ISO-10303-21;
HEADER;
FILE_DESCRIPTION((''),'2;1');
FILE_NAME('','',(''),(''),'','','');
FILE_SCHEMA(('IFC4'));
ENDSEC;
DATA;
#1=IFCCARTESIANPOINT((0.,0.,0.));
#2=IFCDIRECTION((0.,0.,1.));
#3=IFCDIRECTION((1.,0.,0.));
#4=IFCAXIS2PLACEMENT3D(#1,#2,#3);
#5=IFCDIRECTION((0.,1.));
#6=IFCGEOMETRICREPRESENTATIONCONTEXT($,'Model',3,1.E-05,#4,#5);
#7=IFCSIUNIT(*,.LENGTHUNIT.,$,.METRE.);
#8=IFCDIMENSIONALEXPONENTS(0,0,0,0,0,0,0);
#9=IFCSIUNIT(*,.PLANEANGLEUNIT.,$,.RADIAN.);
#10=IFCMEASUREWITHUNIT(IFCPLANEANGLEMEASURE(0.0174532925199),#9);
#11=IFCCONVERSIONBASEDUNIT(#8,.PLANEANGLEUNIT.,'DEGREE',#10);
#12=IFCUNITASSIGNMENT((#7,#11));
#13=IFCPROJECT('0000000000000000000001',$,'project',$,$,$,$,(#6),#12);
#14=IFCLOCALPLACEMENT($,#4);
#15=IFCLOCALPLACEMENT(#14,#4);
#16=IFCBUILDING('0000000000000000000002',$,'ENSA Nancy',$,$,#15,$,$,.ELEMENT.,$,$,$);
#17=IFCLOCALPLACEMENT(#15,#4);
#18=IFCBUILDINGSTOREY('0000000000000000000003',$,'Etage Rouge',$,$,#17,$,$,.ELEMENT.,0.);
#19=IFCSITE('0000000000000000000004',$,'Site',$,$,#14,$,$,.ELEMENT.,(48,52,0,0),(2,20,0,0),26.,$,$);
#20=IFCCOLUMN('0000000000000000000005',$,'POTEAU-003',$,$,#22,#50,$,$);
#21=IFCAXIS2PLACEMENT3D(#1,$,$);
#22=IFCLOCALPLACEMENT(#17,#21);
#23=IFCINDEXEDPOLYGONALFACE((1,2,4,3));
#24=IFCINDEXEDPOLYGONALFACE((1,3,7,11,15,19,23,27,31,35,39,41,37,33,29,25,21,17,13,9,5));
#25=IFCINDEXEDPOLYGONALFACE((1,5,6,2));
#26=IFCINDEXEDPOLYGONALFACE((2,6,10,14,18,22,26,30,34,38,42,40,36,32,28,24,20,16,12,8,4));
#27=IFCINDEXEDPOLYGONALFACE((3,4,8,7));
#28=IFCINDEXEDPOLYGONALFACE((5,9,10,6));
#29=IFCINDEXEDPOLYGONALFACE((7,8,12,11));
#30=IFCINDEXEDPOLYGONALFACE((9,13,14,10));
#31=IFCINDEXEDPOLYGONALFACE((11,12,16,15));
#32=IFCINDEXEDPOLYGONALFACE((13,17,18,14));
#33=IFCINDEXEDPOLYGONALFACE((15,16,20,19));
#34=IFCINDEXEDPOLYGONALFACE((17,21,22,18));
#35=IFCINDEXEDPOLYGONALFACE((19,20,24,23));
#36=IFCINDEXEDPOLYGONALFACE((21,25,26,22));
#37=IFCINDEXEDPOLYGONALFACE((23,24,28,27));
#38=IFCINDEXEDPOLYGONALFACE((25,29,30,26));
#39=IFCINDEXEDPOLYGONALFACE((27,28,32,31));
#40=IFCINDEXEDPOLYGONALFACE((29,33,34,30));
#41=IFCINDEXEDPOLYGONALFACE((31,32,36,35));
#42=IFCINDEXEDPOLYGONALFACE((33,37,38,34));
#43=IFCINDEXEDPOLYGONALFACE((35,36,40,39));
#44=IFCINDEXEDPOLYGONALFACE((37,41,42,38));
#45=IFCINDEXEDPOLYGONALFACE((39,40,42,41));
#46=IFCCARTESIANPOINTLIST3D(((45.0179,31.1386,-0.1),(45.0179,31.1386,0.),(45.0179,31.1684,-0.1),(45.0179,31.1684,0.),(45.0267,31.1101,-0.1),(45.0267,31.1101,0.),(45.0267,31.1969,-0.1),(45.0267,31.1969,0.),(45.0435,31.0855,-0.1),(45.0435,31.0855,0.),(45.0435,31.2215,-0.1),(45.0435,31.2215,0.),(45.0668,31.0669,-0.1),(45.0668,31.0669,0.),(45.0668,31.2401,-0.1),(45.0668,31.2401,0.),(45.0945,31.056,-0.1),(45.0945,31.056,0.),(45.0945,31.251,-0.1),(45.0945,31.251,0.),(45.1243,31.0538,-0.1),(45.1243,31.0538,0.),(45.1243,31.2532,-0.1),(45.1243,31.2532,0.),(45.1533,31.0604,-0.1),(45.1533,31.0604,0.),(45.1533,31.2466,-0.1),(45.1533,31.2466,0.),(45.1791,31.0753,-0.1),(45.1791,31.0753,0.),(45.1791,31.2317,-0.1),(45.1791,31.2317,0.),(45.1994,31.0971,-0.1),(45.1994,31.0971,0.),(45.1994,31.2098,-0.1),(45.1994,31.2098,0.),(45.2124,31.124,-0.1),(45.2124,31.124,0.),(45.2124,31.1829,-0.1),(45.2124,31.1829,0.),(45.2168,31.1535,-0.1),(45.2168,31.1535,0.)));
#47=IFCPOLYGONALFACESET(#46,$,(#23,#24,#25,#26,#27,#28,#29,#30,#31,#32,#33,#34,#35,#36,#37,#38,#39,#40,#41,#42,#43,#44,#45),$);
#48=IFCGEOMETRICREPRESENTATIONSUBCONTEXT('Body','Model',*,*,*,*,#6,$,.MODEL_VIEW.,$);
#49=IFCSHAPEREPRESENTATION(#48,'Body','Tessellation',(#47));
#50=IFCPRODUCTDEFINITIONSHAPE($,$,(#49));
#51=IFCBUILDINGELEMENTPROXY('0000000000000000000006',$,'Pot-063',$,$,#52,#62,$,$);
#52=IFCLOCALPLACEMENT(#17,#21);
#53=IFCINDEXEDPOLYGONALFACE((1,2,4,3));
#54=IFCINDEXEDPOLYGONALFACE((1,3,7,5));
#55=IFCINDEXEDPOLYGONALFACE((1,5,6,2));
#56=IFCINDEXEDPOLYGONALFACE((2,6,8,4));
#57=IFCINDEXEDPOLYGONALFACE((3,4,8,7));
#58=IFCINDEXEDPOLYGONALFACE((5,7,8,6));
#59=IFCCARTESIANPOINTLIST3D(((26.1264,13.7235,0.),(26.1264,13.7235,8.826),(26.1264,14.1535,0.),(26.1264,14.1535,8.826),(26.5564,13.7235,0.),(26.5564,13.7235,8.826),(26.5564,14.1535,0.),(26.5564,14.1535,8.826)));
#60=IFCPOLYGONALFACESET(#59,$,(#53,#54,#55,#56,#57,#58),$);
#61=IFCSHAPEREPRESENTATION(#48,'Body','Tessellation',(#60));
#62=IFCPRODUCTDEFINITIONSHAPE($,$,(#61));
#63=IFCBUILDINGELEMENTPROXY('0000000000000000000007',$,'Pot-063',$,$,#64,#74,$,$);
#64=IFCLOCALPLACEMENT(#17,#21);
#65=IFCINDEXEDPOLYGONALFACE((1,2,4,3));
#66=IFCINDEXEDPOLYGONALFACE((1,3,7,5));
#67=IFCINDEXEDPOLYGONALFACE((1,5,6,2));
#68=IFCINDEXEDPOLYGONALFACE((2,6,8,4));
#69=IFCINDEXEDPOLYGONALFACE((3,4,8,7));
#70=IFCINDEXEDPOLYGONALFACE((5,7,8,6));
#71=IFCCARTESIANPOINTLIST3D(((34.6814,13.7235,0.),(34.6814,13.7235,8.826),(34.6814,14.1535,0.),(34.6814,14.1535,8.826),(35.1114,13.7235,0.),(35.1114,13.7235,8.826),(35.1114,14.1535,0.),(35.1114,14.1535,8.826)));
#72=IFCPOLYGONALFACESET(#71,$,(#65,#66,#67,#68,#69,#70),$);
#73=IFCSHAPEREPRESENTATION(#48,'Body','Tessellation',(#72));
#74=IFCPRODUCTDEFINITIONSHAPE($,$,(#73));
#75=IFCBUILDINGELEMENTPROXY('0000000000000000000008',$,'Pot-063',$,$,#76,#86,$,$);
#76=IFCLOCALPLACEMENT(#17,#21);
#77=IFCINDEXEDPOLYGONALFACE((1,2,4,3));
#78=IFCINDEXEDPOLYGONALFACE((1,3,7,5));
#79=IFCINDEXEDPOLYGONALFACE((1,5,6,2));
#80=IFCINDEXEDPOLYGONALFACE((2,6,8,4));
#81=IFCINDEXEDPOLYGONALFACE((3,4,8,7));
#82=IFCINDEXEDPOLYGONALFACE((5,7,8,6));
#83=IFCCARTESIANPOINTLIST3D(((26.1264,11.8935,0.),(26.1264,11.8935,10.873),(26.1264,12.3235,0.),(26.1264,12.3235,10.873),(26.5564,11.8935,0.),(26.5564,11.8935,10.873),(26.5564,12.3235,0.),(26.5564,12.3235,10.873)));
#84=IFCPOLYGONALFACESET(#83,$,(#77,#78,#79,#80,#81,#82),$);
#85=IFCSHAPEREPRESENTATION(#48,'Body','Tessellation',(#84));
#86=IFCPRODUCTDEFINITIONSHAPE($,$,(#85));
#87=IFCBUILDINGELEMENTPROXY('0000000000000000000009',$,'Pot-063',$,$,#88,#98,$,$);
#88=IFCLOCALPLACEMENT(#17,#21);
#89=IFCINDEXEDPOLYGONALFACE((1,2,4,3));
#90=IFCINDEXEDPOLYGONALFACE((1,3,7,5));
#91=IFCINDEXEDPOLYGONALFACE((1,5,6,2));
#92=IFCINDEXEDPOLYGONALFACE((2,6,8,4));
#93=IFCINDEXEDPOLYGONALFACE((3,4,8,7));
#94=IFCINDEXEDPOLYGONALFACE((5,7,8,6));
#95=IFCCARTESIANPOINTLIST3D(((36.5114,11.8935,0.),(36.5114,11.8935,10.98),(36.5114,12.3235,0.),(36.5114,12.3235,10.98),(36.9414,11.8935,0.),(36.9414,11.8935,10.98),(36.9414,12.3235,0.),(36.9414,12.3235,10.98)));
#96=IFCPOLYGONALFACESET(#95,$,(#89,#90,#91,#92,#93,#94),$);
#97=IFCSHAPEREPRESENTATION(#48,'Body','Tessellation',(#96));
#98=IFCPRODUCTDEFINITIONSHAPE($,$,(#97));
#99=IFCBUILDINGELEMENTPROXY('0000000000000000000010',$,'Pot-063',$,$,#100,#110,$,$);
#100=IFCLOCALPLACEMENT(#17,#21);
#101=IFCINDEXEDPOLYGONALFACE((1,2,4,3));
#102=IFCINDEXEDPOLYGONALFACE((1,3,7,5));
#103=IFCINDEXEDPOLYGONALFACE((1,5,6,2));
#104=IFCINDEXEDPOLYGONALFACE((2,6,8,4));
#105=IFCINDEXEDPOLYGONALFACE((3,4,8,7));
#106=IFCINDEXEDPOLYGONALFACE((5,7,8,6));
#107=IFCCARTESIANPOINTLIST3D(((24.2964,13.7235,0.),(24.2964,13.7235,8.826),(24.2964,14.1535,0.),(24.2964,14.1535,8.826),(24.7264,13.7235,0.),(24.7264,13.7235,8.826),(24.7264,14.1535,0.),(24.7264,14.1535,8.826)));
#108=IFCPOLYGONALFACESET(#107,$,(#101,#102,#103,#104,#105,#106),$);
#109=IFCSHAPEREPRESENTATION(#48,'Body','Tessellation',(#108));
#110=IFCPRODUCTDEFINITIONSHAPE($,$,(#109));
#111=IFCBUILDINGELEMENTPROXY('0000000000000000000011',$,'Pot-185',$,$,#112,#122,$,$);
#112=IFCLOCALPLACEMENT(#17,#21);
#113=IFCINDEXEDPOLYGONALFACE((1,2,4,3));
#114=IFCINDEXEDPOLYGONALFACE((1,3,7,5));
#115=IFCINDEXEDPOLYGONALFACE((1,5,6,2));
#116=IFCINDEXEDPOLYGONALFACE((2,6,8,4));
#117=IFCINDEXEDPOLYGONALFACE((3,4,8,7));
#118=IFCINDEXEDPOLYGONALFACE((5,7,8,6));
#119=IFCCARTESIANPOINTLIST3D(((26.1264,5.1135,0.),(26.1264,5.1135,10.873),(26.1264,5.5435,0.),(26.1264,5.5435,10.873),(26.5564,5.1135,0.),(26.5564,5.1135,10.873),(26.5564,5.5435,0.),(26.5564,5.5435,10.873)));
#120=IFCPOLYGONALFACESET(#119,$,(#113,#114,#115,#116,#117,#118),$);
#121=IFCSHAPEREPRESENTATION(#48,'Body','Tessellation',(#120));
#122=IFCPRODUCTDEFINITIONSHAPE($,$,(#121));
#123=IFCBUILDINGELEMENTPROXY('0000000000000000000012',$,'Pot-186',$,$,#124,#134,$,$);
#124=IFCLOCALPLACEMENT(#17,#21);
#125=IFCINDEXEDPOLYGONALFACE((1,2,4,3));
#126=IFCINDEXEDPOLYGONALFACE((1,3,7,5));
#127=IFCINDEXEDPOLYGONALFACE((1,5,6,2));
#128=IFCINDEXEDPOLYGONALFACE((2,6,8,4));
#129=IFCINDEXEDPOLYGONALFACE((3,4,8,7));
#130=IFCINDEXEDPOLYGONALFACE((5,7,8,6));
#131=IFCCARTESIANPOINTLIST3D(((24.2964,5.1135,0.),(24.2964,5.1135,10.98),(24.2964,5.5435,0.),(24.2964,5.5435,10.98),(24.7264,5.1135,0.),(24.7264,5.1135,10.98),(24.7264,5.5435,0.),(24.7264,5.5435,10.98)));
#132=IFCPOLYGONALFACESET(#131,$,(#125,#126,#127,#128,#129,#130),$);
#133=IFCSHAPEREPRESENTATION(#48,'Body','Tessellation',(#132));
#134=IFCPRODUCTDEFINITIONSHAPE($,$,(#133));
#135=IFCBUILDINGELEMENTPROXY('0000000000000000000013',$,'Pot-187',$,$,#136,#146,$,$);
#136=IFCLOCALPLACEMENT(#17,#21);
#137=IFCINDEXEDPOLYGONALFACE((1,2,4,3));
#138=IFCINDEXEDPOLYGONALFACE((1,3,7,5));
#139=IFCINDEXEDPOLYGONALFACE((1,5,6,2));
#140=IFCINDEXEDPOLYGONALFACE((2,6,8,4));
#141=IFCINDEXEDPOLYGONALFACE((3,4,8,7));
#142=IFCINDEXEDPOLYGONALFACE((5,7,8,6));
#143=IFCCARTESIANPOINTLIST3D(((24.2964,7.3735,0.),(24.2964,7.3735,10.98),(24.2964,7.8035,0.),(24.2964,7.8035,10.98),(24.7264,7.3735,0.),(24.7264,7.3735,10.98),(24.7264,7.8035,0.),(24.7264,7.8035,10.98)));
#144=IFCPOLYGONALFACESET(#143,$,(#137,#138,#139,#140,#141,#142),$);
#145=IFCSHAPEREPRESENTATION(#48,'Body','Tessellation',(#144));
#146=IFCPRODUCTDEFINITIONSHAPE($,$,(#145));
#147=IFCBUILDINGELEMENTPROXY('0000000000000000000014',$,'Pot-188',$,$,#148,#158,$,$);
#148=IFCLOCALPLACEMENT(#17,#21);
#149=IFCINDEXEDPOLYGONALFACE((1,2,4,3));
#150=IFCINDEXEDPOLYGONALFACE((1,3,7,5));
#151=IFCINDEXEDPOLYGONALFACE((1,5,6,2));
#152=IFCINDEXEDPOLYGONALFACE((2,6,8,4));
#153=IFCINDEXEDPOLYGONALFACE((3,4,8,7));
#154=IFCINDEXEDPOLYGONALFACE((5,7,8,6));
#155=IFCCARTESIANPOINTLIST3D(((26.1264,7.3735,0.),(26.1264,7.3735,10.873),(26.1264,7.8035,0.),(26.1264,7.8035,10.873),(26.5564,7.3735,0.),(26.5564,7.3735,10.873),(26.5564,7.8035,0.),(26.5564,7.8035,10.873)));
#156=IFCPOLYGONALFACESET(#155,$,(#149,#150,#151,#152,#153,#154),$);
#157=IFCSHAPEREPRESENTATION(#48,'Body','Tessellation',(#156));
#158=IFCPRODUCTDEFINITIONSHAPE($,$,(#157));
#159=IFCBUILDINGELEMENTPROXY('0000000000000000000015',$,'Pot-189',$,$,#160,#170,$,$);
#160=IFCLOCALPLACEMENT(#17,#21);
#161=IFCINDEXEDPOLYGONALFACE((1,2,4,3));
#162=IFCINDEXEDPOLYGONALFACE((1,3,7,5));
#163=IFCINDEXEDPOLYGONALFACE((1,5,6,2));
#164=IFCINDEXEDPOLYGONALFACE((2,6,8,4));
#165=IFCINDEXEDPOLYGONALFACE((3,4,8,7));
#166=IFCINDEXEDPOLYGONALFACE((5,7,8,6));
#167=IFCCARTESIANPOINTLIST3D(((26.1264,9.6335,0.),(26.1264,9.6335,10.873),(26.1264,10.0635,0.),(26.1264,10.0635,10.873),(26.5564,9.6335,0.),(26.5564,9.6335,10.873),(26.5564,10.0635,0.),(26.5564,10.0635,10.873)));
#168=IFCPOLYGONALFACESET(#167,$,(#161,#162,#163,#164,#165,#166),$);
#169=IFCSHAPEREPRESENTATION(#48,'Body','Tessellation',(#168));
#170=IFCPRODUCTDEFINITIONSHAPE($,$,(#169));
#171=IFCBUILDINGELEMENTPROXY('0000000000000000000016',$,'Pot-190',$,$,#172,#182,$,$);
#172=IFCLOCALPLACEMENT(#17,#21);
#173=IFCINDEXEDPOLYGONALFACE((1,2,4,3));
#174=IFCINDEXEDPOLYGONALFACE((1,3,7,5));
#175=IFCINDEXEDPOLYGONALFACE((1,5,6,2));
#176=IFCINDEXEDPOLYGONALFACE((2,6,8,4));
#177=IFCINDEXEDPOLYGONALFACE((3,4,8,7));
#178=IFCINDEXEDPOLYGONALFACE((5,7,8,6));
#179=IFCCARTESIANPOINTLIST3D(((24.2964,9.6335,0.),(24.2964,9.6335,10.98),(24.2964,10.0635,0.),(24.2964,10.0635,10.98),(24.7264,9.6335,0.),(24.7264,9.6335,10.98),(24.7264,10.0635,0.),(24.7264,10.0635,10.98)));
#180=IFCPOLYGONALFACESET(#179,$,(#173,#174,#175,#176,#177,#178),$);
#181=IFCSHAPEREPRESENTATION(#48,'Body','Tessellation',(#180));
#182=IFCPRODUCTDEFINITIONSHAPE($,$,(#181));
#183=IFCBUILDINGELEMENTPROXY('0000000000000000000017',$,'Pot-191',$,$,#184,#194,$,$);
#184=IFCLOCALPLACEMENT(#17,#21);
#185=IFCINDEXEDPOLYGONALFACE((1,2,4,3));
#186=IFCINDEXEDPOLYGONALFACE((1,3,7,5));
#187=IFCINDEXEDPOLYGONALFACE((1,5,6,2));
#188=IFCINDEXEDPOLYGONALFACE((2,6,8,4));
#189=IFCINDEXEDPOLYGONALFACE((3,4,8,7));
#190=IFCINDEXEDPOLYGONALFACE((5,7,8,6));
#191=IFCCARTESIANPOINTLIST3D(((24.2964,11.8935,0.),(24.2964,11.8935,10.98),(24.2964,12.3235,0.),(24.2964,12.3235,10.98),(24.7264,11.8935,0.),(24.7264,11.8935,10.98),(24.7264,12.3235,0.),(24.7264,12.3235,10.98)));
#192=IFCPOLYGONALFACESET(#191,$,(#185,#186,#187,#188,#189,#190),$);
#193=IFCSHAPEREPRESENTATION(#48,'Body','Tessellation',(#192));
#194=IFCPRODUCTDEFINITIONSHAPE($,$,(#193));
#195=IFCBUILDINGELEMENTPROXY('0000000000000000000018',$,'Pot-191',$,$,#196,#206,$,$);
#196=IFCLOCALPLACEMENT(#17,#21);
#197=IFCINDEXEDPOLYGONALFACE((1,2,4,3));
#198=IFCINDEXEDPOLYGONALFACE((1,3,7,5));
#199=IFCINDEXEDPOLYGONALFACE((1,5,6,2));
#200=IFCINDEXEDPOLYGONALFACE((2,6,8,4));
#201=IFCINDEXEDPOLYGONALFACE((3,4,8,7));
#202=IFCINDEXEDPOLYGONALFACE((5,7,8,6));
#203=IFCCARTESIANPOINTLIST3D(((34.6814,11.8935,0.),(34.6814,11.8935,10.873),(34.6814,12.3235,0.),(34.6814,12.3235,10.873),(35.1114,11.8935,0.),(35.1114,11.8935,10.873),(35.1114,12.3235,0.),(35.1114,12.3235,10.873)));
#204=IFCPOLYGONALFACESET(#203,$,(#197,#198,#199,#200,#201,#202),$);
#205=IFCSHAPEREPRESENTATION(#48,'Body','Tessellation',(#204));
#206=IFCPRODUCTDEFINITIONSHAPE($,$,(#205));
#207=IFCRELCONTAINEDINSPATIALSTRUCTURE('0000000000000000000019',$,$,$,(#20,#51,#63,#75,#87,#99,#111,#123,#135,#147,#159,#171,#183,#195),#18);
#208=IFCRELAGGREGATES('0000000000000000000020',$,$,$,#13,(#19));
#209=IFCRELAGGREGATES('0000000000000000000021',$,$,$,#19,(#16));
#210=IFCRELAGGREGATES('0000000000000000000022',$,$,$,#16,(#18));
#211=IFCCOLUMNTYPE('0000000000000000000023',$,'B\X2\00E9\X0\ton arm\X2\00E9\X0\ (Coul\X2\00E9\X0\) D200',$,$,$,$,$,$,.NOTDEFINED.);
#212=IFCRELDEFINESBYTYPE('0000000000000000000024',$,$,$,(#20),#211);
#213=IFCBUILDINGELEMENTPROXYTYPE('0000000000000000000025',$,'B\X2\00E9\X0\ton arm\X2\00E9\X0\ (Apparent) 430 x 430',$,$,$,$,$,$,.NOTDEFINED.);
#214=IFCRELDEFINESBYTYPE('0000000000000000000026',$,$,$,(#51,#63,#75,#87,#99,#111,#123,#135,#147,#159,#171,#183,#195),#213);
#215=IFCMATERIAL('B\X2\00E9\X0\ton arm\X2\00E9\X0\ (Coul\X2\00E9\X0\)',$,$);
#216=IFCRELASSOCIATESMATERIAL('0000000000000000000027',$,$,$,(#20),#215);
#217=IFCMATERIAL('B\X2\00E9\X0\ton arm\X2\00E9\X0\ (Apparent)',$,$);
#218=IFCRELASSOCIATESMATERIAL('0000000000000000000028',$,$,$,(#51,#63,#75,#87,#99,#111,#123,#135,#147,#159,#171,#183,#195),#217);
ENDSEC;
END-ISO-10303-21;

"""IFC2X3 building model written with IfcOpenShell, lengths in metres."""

from ifc_helpers import new_model, entity, si_unit, converted_unit, direction, frame, origin_with_axes, origin_2d_with_axis, place, context, subcontext, project, spatial, rectangle, circle, extrude, material, type_object, element, save


model = new_model("IFC2X3")

# Units and contexts
model_context = context("Model", 3, precision=1e-05, world=origin_with_axes(), true_north=direction((0.0, 1.0)))
body_context = subcontext(model_context, "Body", "Model", "MODEL_VIEW")
ifc_project = project(units=[si_unit("LENGTHUNIT", "METRE"), converted_unit("PLANEANGLEUNIT", "DEGREE", entity("IfcPlaneAngleMeasure", 0.0174532925199), si_unit("PLANEANGLEUNIT", "RADIAN"), dimensions=[0, 0, 0, 0, 0, 0, 0])], contexts=[model_context])

# Site, building, storey
site_placement = place(None, origin_with_axes())
site = spatial("IfcSite", under=ifc_project, at=site_placement, Name="Site", CompositionType="ELEMENT", RefLatitude=(48, 52, 0, 0), RefLongitude=(2, 20, 0, 0), RefElevation=26.0)
building_placement = place(site_placement, origin_with_axes())
building = spatial("IfcBuilding", under=site, at=building_placement, Name="ENSA Nancy", CompositionType="ELEMENT")
storey_placement = place(building_placement, origin_with_axes())
storey = spatial("IfcBuildingStorey", under=building, at=storey_placement, Name="Etage Rouge", CompositionType="ELEMENT", Elevation=0.0)

# Column
ifc_material_1 = material(Name="Béton armé (Coulé)")
column_type = type_object("IfcColumnType", Name="Béton armé (Coulé) D200", PredefinedType="NOTDEFINED")
column_placement = place(storey_placement, frame((45.1168, 31.1535, -0.1), z_axis=(0.0, 0.0, 1.0), x_axis=(1.0, 0.0, 0.0)))
element("IfcColumn", 1, at=column_placement, inside=storey, type_object=column_type, material=ifc_material_1, Name="POTEAU-003", context=body_context, shape_type="SweptSolid", body=[
    extrude(circle(Radius=0.1, at=origin_2d_with_axis()), origin_with_axes(), (0.0, 0.0, 1.0), 0.1),
])

# Building element proxies
ifc_material_2 = material(Name="Béton armé (Apparent)")
building_element_proxy_type_1 = type_object("IfcBuildingElementProxyType", Name="Béton armé (Apparent) 430 x 430", PredefinedType="NOTDEFINED")
for number, where, z_axis, x_axis, name in (
    (2, (26.3414, 13.9385, 0.0), (0.0, 0.0, 1.0), (1.0, 0.0, 0.0), "Pot-063"),
    (3, (34.8964, 13.9385, 0.0), (0.0, 0.0, 1.0), (1.0, 0.0, 0.0), "Pot-063"),
):
    element("IfcBuildingElementProxy", number, at=place(storey_placement, frame(where, z_axis=z_axis, x_axis=x_axis)), inside=storey, type_object=building_element_proxy_type_1, material=ifc_material_2, Name=name, context=body_context, shape_type="SweptSolid", body=[
        extrude(rectangle(XDim=0.43, YDim=0.43, at=origin_2d_with_axis()), origin_with_axes(), (0.0, 0.0, 1.0), 8.826),
    ])
proxy_1_placement = place(storey_placement, frame((26.3414, 12.1085, 0.0), z_axis=(0.0, 0.0, 1.0), x_axis=(1.0, 0.0, 0.0)))
element("IfcBuildingElementProxy", 4, at=proxy_1_placement, inside=storey, type_object=building_element_proxy_type_1, material=ifc_material_2, Name="Pot-063", context=body_context, shape_type="SweptSolid", body=[
    extrude(rectangle(XDim=0.43, YDim=0.43, at=origin_2d_with_axis()), origin_with_axes(), (0.0, 0.0, 1.0), 10.873),
])
proxy_2_placement = place(storey_placement, frame((36.7264, 12.1085, 0.0), z_axis=(0.0, 0.0, 1.0), x_axis=(1.0, 0.0, 0.0)))
element("IfcBuildingElementProxy", 5, at=proxy_2_placement, inside=storey, type_object=building_element_proxy_type_1, material=ifc_material_2, Name="Pot-063", context=body_context, shape_type="SweptSolid", body=[
    extrude(rectangle(XDim=0.43, YDim=0.43, at=origin_2d_with_axis()), origin_with_axes(), (0.0, 0.0, 1.0), 10.98),
])
proxy_3_placement = place(storey_placement, frame((24.5114, 13.9385, 0.0), z_axis=(0.0, 0.0, 1.0), x_axis=(1.0, 0.0, 0.0)))
element("IfcBuildingElementProxy", 6, at=proxy_3_placement, inside=storey, type_object=building_element_proxy_type_1, material=ifc_material_2, Name="Pot-063", context=body_context, shape_type="SweptSolid", body=[
    extrude(rectangle(XDim=0.43, YDim=0.43, at=origin_2d_with_axis()), origin_with_axes(), (0.0, 0.0, 1.0), 8.826),
])
proxy_4_placement = place(storey_placement, frame((26.3414, 5.3285, 0.0), z_axis=(0.0, 0.0, 1.0), x_axis=(1.0, 0.0, 0.0)))
element("IfcBuildingElementProxy", 7, at=proxy_4_placement, inside=storey, type_object=building_element_proxy_type_1, material=ifc_material_2, Name="Pot-185", context=body_context, shape_type="SweptSolid", body=[
    extrude(rectangle(XDim=0.43, YDim=0.43, at=origin_2d_with_axis()), origin_with_axes(), (0.0, 0.0, 1.0), 10.873),
])
for number, where, z_axis, x_axis, name in (
    (8, (24.5114, 5.3285, 0.0), (0.0, 0.0, 1.0), (1.0, 0.0, 0.0), "Pot-186"),
    (9, (24.5114, 7.5885, 0.0), (0.0, 0.0, 1.0), (1.0, 0.0, 0.0), "Pot-187"),
):
    element("IfcBuildingElementProxy", number, at=place(storey_placement, frame(where, z_axis=z_axis, x_axis=x_axis)), inside=storey, type_object=building_element_proxy_type_1, material=ifc_material_2, Name=name, context=body_context, shape_type="SweptSolid", body=[
        extrude(rectangle(XDim=0.43, YDim=0.43, at=origin_2d_with_axis()), origin_with_axes(), (0.0, 0.0, 1.0), 10.98),
    ])
for number, where, z_axis, x_axis, name in (
    (10, (26.3414, 7.5885, 0.0), (0.0, 0.0, 1.0), (1.0, 0.0, 0.0), "Pot-188"),
    (11, (26.3414, 9.8485, 0.0), (0.0, 0.0, 1.0), (1.0, 0.0, 0.0), "Pot-189"),
):
    element("IfcBuildingElementProxy", number, at=place(storey_placement, frame(where, z_axis=z_axis, x_axis=x_axis)), inside=storey, type_object=building_element_proxy_type_1, material=ifc_material_2, Name=name, context=body_context, shape_type="SweptSolid", body=[
        extrude(rectangle(XDim=0.43, YDim=0.43, at=origin_2d_with_axis()), origin_with_axes(), (0.0, 0.0, 1.0), 10.873),
    ])
for number, where, z_axis, x_axis, name in (
    (12, (24.5114, 9.8485, 0.0), (0.0, 0.0, 1.0), (1.0, 0.0, 0.0), "Pot-190"),
    (13, (24.5114, 12.1085, 0.0), (0.0, 0.0, 1.0), (1.0, 0.0, 0.0), "Pot-191"),
):
    element("IfcBuildingElementProxy", number, at=place(storey_placement, frame(where, z_axis=z_axis, x_axis=x_axis)), inside=storey, type_object=building_element_proxy_type_1, material=ifc_material_2, Name=name, context=body_context, shape_type="SweptSolid", body=[
        extrude(rectangle(XDim=0.43, YDim=0.43, at=origin_2d_with_axis()), origin_with_axes(), (0.0, 0.0, 1.0), 10.98),
    ])
proxy_5_placement = place(storey_placement, frame((34.8964, 12.1085, 0.0), z_axis=(0.0, 0.0, 1.0), x_axis=(1.0, 0.0, 0.0)))
element("IfcBuildingElementProxy", 14, at=proxy_5_placement, inside=storey, type_object=building_element_proxy_type_1, material=ifc_material_2, Name="Pot-191", context=body_context, shape_type="SweptSolid", body=[
    extrude(rectangle(XDim=0.43, YDim=0.43, at=origin_2d_with_axis()), origin_with_axes(), (0.0, 0.0, 1.0), 10.873),
])

save(model, "model.ifc")
